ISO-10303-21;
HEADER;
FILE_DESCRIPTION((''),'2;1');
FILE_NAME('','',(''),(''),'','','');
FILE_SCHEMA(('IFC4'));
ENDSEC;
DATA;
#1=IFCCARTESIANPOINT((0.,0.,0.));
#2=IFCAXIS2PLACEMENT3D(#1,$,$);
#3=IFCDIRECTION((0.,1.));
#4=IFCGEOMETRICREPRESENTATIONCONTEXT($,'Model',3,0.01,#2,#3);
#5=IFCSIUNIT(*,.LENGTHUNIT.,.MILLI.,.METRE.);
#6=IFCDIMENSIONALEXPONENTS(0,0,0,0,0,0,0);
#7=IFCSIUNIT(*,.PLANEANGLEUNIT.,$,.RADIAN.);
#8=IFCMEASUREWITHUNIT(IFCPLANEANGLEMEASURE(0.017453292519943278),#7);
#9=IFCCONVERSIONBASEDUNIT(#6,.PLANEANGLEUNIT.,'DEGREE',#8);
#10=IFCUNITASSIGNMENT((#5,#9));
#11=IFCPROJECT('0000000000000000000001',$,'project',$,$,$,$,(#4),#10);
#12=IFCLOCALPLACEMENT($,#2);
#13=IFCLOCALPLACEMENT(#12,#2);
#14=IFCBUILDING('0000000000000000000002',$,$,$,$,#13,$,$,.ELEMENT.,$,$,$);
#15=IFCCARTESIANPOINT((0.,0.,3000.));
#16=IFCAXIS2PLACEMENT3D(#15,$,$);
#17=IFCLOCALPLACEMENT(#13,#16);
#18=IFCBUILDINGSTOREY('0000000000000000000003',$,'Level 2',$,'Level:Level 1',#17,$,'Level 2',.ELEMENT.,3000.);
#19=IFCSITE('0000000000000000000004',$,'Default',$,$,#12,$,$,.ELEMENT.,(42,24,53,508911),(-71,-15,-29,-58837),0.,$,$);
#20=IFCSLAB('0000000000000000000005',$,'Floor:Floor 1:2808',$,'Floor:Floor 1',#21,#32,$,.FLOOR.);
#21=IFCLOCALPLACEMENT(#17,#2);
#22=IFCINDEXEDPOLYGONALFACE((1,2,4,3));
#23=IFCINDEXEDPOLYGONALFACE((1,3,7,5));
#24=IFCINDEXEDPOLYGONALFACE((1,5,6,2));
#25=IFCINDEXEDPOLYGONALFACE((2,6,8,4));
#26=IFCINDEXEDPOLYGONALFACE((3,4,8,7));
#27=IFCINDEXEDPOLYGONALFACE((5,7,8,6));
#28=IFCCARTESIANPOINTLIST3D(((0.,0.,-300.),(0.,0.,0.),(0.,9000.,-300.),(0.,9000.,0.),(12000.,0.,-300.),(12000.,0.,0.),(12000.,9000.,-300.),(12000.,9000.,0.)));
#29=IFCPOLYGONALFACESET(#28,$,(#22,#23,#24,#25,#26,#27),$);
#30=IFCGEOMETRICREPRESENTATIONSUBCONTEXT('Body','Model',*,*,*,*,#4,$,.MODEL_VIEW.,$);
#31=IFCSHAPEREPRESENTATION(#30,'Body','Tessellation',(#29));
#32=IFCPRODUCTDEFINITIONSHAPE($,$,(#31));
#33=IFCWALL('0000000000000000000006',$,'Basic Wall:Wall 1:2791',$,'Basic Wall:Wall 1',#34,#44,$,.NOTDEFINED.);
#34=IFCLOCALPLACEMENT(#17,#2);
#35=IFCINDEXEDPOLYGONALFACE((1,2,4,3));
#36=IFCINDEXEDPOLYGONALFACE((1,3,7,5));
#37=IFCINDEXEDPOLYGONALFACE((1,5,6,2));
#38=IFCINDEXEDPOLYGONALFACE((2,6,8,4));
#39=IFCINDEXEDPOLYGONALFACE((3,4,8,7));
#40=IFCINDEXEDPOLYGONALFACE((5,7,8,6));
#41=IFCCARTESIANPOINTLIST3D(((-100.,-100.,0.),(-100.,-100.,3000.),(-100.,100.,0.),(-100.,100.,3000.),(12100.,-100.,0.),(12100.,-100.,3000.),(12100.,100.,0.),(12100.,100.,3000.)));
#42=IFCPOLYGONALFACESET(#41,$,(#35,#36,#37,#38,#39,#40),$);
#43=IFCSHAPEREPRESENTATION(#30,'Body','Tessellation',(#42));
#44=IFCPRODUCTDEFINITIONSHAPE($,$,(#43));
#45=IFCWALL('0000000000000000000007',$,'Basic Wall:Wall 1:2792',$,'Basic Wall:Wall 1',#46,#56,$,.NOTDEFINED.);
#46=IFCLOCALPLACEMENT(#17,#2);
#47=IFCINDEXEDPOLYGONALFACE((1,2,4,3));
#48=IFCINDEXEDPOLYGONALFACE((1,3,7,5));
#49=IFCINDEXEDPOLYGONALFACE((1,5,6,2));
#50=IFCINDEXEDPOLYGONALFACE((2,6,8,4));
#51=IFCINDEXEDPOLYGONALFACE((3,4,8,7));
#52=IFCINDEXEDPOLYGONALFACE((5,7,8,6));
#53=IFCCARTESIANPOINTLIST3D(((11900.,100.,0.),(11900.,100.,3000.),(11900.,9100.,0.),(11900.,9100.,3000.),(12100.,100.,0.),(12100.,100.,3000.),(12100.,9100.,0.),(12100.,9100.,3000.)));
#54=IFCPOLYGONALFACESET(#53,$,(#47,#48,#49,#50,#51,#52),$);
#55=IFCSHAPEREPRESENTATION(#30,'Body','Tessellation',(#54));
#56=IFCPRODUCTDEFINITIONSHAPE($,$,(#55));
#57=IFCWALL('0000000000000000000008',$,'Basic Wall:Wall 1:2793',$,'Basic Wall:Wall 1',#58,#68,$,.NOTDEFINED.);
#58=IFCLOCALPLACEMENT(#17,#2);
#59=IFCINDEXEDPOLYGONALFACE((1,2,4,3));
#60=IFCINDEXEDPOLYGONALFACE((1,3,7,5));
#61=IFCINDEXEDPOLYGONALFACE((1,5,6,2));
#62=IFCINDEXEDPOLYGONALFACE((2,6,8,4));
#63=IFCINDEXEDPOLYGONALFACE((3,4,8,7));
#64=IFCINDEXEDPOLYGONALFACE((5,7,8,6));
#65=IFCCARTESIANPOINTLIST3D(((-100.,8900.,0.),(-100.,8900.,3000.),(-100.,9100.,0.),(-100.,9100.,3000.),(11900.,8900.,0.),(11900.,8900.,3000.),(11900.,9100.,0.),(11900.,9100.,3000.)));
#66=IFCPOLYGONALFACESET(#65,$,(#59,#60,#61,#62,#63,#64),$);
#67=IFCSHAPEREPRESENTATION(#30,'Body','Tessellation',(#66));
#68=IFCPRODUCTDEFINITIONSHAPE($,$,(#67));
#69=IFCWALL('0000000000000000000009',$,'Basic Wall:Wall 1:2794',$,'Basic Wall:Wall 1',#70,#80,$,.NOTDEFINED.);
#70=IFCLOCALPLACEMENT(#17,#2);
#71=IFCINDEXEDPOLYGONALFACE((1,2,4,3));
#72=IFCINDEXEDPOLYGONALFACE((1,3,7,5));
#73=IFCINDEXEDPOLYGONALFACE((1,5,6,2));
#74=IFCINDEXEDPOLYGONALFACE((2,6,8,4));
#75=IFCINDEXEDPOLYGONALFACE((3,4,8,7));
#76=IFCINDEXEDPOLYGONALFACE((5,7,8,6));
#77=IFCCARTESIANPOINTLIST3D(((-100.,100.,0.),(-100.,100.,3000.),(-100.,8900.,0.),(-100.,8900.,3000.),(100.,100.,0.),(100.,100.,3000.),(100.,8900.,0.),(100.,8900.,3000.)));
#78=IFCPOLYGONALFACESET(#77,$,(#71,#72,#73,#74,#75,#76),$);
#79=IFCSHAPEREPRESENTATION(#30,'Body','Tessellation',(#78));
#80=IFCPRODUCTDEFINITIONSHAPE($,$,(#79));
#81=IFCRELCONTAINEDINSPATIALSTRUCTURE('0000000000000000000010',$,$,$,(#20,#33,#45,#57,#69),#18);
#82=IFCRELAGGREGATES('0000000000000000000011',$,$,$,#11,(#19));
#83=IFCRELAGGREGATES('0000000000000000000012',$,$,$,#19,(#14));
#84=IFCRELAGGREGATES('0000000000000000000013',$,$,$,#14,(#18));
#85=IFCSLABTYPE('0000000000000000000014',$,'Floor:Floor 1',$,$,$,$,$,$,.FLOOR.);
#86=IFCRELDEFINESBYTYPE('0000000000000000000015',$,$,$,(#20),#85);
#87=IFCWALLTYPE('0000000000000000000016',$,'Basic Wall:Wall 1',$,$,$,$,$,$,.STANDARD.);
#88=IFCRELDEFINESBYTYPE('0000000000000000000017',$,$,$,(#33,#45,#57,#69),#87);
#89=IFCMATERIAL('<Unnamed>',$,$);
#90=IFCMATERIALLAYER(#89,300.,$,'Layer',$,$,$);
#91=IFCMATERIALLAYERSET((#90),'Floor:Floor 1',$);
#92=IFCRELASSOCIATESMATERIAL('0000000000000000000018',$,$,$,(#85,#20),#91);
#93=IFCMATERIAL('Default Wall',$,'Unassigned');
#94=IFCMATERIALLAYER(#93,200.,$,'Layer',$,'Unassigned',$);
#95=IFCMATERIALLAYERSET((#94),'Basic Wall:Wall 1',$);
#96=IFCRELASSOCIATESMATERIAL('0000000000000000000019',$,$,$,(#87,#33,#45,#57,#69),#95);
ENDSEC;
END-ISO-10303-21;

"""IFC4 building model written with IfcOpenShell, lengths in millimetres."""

from ifc_helpers import new_model, entity, si_unit, converted_unit, direction, frame, frame_2d, origin, origin_2d_with_axis, place, context, subcontext, project, spatial, rectangle, extrude, material, layer, layer_set, layer_usage, type_object, element, save


model = new_model("IFC4")

# Units and contexts
model_context = context("Model", 3, precision=0.01, world=origin(), true_north=direction((0.0, 1.0)))
body_context = subcontext(model_context, "Body", "Model", "MODEL_VIEW")
ifc_project = project(units=[si_unit("LENGTHUNIT", "METRE", prefix="MILLI"), converted_unit("PLANEANGLEUNIT", "DEGREE", entity("IfcPlaneAngleMeasure", 0.017453292519943278), si_unit("PLANEANGLEUNIT", "RADIAN"), dimensions=[0, 0, 0, 0, 0, 0, 0])], contexts=[model_context])

# Site, building, storey
site_placement = place(None, origin())
site = spatial("IfcSite", under=ifc_project, at=site_placement, Name="Default", CompositionType="ELEMENT", RefLatitude=(42, 24, 53, 508911), RefLongitude=(-71, -15, -29, -58837), RefElevation=0.0)
building_placement = place(site_placement, origin())
building = spatial("IfcBuilding", under=site, at=building_placement, CompositionType="ELEMENT")
storey_placement = place(building_placement, frame((0.0, 0.0, 3000.0)))
storey = spatial("IfcBuildingStorey", under=building, at=storey_placement, Name="Level 2", ObjectType="Level:Level 1", LongName="Level 2", CompositionType="ELEMENT", Elevation=3000.0)

# Slab
ifc_material_1 = material(Name="<Unnamed>")
ifc_layer_1 = layer(ifc_material_1, 300.0, Name="Layer")
ifc_layer_set_1 = layer_set([ifc_layer_1], Name="Floor:Floor 1")
ifc_layer_usage_1 = layer_usage(ifc_layer_set_1, "AXIS3", "POSITIVE", 0.0)
slab_type = type_object("IfcSlabType", Name="Floor:Floor 1", PredefinedType="FLOOR", material=ifc_layer_set_1)
slab_placement = place(storey_placement, origin())
element("IfcSlab", 1, at=slab_placement, inside=storey, type_object=slab_type, material=ifc_layer_usage_1, Name="Floor:Floor 1:2808", ObjectType="Floor:Floor 1", PredefinedType="FLOOR", context=body_context, shape_type="SweptSolid", body=[
    extrude(rectangle(XDim=9000.0, YDim=12000.0, at=origin_2d_with_axis()), frame((6000.0, 4500.0, 0.0), z_axis=(0.0, 0.0, -1.0), x_axis=(0.0, 1.0, 0.0)), (0.0, 0.0, 1.0), 300.0),
])

# Walls
ifc_material_2 = material(Name="Default Wall", Category="Unassigned")
ifc_layer_2 = layer(ifc_material_2, 200.0, Name="Layer", Category="Unassigned")
ifc_layer_set_2 = layer_set([ifc_layer_2], Name="Basic Wall:Wall 1")
ifc_layer_usage_2 = layer_usage(ifc_layer_set_2, "AXIS2", "NEGATIVE", 100.0)
wall_type = type_object("IfcWallType", Name="Basic Wall:Wall 1", PredefinedType="STANDARD", material=ifc_layer_set_2)
wall_1_placement = place(storey_placement, frame((-100.0, 0.0, 0.0)))
element("IfcWall", 2, at=wall_1_placement, inside=storey, type_object=wall_type, material=ifc_layer_usage_2, Name="Basic Wall:Wall 1:2791", ObjectType="Basic Wall:Wall 1", PredefinedType="NOTDEFINED", context=body_context, shape_type="SweptSolid", body=[
    extrude(rectangle(XDim=12200.0, YDim=200.0, at=frame_2d((6100.0, 0.0), x_axis=(-1.0, 0.0))), origin(), (0.0, 0.0, 1.0), 3000.0),
])
ifc_layer_usage_3 = layer_usage(ifc_layer_set_2, "AXIS2", "NEGATIVE", 100.0)
wall_2_placement = place(storey_placement, frame((12000.0, 100.0, 0.0), z_axis=(0.0, 0.0, 1.0), x_axis=(0.0, 1.0, 0.0)))
element("IfcWall", 3, at=wall_2_placement, inside=storey, type_object=wall_type, material=ifc_layer_usage_3, Name="Basic Wall:Wall 1:2792", ObjectType="Basic Wall:Wall 1", PredefinedType="NOTDEFINED", context=body_context, shape_type="SweptSolid", body=[
    extrude(rectangle(XDim=9000.0, YDim=200.0, at=frame_2d((4500.0, 0.0), x_axis=(-1.0, 0.0))), origin(), (0.0, 0.0, 1.0), 3000.0),
])
ifc_layer_usage_4 = layer_usage(ifc_layer_set_2, "AXIS2", "NEGATIVE", 100.0)
wall_3_placement = place(storey_placement, frame((11900.0, 9000.0, 0.0), z_axis=(0.0, 0.0, 1.0), x_axis=(-1.0, 0.0, 0.0)))
element("IfcWall", 4, at=wall_3_placement, inside=storey, type_object=wall_type, material=ifc_layer_usage_4, Name="Basic Wall:Wall 1:2793", ObjectType="Basic Wall:Wall 1", PredefinedType="NOTDEFINED", context=body_context, shape_type="SweptSolid", body=[
    extrude(rectangle(XDim=12000.0, YDim=200.0, at=frame_2d((6000.0, 0.0), x_axis=(-1.0, 0.0))), origin(), (0.0, 0.0, 1.0), 3000.0),
])
ifc_layer_usage_5 = layer_usage(ifc_layer_set_2, "AXIS2", "NEGATIVE", 100.0)
wall_4_placement = place(storey_placement, frame((0.0, 8900.0, 0.0), z_axis=(0.0, 0.0, 1.0), x_axis=(0.0, -1.0, 0.0)))
element("IfcWall", 5, at=wall_4_placement, inside=storey, type_object=wall_type, material=ifc_layer_usage_5, Name="Basic Wall:Wall 1:2794", ObjectType="Basic Wall:Wall 1", PredefinedType="NOTDEFINED", context=body_context, shape_type="SweptSolid", body=[
    extrude(rectangle(XDim=8800.0, YDim=200.0, at=frame_2d((4400.0, 0.0), x_axis=(-1.0, 0.0))), origin(), (0.0, 0.0, 1.0), 3000.0),
])

save(model, "model.ifc")
